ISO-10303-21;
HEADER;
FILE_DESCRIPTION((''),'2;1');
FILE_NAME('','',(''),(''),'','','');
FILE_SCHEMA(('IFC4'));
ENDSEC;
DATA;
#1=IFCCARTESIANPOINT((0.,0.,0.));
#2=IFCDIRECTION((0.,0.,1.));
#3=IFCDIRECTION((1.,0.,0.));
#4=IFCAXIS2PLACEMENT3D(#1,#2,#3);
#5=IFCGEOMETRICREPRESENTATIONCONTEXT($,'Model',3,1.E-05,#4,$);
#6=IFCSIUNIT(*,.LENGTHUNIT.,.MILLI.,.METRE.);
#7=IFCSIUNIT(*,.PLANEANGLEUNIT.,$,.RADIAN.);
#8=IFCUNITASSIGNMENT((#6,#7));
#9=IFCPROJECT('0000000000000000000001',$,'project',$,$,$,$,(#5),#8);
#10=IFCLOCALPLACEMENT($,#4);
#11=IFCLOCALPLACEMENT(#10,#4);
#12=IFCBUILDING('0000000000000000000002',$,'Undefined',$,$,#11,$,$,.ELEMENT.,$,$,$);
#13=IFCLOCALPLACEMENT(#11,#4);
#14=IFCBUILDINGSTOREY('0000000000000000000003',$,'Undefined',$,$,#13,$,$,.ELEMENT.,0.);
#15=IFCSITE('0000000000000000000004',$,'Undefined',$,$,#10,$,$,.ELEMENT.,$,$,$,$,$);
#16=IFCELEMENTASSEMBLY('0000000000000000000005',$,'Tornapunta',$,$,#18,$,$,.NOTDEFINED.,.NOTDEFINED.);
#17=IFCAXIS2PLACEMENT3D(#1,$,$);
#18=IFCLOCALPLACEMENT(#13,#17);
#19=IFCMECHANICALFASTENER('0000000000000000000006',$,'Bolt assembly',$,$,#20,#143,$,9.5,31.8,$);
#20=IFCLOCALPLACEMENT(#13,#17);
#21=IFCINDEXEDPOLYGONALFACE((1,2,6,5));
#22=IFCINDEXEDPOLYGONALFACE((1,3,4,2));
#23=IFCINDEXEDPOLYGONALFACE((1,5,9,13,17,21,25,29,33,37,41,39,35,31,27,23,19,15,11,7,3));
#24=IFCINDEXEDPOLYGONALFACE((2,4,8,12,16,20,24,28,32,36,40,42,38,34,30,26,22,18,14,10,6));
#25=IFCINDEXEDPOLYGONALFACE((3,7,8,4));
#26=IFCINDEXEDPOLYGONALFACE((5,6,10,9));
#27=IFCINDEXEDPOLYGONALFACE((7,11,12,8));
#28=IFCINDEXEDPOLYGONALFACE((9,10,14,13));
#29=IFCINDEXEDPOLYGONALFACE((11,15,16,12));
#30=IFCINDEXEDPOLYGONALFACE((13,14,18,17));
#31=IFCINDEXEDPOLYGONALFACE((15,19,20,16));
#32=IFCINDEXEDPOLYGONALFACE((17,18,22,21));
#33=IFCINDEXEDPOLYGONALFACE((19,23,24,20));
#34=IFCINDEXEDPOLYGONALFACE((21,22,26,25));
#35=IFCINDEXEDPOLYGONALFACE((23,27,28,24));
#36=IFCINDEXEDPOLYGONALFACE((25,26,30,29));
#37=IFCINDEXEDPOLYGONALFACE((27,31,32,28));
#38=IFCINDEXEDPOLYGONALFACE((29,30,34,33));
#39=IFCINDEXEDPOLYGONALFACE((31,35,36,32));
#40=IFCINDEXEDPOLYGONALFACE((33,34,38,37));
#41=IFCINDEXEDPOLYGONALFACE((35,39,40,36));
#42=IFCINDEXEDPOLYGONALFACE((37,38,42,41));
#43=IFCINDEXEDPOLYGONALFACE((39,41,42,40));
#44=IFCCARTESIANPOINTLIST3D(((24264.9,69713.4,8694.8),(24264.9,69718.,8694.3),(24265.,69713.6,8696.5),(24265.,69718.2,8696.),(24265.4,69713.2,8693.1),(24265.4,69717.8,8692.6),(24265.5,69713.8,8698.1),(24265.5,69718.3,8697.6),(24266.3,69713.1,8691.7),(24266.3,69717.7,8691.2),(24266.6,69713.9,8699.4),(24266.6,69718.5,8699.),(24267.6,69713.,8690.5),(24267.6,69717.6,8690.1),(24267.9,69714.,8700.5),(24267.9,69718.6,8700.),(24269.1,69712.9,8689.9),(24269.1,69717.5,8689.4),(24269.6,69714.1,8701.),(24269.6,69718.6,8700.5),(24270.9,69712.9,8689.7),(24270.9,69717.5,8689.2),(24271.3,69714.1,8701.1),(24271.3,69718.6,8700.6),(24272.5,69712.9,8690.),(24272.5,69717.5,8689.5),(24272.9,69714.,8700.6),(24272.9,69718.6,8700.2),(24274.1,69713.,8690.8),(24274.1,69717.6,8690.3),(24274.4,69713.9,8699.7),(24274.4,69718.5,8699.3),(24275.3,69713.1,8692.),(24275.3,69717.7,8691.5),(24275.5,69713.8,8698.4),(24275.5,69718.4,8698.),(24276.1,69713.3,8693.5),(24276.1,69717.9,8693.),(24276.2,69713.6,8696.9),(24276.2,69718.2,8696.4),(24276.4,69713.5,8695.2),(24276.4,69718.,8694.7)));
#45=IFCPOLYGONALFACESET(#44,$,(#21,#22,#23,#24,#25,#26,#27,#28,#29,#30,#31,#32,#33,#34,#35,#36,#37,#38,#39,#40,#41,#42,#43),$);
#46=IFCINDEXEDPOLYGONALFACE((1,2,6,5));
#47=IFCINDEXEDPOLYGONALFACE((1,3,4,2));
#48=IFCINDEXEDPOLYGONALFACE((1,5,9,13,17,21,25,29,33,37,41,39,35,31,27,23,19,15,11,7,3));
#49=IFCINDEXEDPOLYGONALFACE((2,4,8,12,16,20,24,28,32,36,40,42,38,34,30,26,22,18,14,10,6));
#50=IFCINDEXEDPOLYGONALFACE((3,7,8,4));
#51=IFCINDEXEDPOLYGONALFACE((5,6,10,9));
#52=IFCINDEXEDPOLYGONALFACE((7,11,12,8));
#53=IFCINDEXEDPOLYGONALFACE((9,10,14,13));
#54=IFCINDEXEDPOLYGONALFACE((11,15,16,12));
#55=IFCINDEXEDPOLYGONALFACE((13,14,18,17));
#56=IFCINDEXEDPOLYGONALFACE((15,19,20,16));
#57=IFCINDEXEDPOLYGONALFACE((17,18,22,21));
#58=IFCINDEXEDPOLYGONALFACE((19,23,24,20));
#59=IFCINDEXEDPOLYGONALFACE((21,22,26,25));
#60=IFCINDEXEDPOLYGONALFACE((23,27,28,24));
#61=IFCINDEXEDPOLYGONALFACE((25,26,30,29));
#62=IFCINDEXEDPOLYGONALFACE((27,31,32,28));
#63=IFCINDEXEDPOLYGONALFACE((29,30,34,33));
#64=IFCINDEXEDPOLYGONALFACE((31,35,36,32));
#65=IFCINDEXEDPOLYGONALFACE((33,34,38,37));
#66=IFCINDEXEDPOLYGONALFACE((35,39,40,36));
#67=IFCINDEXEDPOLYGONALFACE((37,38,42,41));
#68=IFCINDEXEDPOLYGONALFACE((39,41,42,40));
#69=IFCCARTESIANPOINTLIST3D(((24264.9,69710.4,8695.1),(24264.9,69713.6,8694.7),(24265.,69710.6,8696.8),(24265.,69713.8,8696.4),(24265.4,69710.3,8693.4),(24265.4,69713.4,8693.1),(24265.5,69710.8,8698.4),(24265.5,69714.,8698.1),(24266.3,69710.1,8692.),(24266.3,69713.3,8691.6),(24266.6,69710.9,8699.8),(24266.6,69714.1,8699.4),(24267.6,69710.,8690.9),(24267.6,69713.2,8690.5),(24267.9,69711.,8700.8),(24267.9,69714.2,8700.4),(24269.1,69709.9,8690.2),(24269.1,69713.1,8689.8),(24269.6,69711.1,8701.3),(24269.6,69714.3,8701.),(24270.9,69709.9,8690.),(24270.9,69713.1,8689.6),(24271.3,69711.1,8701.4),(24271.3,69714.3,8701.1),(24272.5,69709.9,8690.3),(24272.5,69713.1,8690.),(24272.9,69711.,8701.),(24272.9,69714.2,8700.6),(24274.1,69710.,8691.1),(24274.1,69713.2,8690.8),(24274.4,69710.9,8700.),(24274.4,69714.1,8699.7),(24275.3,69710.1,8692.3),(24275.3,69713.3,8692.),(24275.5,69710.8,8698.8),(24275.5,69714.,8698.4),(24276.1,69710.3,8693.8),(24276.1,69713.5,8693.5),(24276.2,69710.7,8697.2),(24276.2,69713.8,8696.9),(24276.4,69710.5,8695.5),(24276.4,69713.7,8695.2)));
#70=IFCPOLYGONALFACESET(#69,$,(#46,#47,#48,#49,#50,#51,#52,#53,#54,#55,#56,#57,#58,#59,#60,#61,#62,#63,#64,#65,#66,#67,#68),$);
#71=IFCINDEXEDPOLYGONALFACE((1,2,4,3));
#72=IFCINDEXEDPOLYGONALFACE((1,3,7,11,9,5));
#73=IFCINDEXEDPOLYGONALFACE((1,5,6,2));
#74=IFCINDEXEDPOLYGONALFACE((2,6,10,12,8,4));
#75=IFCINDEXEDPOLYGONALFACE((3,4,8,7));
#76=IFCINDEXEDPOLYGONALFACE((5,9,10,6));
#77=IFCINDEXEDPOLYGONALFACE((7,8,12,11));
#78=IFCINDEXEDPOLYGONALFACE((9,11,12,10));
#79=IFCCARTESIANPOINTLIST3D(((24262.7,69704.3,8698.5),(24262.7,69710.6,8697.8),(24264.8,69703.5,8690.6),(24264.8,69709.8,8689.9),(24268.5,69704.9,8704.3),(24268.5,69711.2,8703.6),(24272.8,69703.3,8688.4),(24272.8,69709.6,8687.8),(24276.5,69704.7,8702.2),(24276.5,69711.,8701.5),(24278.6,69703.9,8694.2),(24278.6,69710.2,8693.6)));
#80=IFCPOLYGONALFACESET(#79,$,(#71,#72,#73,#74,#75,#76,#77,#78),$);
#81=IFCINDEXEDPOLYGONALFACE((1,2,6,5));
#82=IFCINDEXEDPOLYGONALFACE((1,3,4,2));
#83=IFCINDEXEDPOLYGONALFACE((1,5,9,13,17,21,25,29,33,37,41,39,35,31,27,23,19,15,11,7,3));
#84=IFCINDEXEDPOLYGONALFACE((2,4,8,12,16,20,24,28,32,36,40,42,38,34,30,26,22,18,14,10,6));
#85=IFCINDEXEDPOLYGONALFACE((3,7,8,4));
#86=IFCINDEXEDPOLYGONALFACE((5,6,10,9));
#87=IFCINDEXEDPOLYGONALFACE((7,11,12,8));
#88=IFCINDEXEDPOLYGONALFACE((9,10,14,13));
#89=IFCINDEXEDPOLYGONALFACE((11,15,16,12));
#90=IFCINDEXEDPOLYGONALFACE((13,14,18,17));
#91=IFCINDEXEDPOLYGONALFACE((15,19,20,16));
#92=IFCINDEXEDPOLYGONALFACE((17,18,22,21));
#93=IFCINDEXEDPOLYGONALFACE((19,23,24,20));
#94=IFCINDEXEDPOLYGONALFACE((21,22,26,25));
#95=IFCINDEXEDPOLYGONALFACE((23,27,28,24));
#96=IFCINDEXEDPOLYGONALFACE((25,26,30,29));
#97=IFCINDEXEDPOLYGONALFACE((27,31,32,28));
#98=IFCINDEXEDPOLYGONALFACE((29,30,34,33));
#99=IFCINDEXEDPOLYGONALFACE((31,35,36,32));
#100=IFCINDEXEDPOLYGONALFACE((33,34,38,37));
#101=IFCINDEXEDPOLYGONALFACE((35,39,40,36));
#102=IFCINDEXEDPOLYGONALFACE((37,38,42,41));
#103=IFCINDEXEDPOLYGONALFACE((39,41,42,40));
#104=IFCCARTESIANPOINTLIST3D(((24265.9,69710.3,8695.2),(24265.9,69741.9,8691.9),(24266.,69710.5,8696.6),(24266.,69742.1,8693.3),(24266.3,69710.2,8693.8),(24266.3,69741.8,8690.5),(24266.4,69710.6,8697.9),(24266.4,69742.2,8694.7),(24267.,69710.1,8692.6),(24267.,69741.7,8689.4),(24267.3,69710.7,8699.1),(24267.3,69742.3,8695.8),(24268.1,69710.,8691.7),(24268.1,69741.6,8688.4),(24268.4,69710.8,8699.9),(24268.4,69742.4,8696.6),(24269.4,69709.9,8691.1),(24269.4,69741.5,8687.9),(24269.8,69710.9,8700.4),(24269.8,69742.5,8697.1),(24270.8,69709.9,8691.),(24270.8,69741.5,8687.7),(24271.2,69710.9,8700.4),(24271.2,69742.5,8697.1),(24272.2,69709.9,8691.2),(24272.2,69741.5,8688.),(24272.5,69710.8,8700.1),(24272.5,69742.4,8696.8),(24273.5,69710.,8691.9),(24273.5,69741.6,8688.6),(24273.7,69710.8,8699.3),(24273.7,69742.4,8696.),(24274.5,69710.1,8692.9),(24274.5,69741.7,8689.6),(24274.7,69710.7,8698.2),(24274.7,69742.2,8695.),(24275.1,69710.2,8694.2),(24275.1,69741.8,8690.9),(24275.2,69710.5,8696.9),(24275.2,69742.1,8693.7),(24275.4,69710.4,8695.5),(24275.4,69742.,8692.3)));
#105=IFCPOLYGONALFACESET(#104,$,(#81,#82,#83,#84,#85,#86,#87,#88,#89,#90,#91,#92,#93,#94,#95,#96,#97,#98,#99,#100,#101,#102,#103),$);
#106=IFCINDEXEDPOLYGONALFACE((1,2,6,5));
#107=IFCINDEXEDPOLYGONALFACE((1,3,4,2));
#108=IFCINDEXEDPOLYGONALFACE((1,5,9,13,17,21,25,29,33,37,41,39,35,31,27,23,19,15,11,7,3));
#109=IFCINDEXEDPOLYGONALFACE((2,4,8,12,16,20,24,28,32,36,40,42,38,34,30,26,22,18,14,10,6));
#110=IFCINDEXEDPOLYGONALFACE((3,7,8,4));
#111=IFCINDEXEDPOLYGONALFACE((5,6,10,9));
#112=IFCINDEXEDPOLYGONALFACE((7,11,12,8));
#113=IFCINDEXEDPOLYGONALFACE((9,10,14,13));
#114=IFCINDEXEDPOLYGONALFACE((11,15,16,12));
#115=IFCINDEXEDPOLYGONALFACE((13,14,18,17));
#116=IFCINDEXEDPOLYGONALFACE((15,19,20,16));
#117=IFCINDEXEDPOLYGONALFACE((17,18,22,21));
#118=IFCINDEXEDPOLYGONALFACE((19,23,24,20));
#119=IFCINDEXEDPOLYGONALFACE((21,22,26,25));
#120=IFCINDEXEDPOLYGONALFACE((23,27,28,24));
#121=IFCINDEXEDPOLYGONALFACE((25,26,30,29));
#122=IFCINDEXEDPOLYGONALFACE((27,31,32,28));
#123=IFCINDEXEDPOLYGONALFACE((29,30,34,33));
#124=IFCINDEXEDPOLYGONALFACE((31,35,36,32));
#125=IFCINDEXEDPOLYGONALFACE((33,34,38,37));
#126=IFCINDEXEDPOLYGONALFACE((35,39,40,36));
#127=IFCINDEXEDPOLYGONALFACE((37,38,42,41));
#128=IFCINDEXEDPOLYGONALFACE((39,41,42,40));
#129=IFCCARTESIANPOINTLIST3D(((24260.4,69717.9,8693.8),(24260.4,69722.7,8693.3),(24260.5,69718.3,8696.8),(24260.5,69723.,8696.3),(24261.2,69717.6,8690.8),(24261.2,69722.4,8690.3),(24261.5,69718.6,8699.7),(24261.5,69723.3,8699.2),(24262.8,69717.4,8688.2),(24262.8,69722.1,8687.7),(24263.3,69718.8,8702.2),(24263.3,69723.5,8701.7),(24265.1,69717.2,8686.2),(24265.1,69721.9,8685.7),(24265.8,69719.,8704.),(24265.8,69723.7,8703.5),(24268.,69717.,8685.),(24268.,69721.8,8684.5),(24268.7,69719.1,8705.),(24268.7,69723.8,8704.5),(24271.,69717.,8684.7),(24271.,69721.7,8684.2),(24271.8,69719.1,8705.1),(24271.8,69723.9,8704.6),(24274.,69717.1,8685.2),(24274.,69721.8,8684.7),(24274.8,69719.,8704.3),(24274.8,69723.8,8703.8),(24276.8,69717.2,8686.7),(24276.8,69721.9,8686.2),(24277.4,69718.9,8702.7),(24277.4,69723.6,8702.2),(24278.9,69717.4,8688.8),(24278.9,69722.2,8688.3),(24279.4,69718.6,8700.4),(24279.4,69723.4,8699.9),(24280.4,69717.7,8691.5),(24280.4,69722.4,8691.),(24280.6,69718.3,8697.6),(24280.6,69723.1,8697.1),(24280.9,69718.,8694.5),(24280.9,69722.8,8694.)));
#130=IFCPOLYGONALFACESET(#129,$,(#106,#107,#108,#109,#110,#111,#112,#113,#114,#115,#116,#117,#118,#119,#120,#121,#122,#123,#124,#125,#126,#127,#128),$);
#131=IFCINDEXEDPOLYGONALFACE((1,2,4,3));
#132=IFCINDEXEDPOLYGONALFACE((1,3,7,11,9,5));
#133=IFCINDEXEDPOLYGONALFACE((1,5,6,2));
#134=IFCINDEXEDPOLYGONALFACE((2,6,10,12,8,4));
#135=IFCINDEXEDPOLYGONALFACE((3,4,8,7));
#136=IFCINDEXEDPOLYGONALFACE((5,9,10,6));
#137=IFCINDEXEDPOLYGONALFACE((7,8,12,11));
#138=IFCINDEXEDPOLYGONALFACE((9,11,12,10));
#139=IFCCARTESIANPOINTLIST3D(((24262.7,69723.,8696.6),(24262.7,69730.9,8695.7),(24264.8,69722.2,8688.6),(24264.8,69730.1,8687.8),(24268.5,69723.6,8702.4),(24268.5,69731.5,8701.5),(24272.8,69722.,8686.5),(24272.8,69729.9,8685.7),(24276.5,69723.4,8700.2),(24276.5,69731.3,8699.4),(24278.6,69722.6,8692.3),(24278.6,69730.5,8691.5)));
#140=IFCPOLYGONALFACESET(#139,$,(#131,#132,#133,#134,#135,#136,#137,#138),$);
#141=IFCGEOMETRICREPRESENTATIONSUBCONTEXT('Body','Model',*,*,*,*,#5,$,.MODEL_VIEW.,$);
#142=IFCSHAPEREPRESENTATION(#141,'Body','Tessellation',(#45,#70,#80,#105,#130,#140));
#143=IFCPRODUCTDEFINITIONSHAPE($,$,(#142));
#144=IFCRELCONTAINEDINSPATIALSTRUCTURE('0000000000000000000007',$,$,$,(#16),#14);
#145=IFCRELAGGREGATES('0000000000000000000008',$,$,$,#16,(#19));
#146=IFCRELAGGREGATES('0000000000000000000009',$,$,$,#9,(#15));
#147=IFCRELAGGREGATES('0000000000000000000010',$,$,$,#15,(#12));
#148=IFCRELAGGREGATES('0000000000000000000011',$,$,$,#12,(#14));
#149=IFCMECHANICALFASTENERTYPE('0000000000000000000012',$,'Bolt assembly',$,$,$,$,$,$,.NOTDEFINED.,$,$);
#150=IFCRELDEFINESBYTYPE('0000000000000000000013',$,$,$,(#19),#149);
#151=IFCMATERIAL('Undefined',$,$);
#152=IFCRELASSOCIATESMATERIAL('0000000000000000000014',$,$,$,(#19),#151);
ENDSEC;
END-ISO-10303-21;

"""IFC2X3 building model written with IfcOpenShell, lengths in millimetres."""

from ifc_helpers import new_model, si_unit, frame, origin_with_axes, origin_2d_with_axis, place, context, subcontext, project, spatial, polyline, circle, outline, extrude, source, transform, mapped, material, type_object, element, aggregate, save


model = new_model("IFC2X3")

# Units and contexts
model_context = context("Model", 3, precision=1e-05, world=origin_with_axes())
body_context = subcontext(model_context, "Body", "Model", "MODEL_VIEW")
ifc_project = project(units=[si_unit("LENGTHUNIT", "METRE", prefix="MILLI"), si_unit("PLANEANGLEUNIT", "RADIAN")], contexts=[model_context])

# Site, building, storey
site_placement = place(None, origin_with_axes())
site = spatial("IfcSite", under=ifc_project, at=site_placement, Name="Undefined", CompositionType="ELEMENT")
building_placement = place(site_placement, origin_with_axes())
building = spatial("IfcBuilding", under=site, at=building_placement, Name="Undefined", CompositionType="ELEMENT")
storey_placement = place(building_placement, origin_with_axes())
storey = spatial("IfcBuildingStorey", under=building, at=storey_placement, Name="Undefined", CompositionType="ELEMENT", Elevation=0.0)

# Element assembly
assembly_1_placement = place(storey_placement, origin_with_axes())
assembly_1 = element("IfcElementAssembly", 1, at=assembly_1_placement, inside=storey, Name="Tornapunta", AssemblyPlace="NOTDEFINED", PredefinedType="NOTDEFINED")
ifc_material_1 = material(Name="Undefined")
mechanical_fastener_type = type_object("IfcMechanicalFastenerType", Name="Bolt assembly")

# Mechanical fastener
shared_shape_1 = source(origin_with_axes(), body_context, "Body", "SweptSolid", [
    extrude(circle(Radius=5.8, at=origin_2d_with_axis()), frame((0.0, -0.1, 0.0), z_axis=(0.0, 1.0, 0.0), x_axis=(1.0, 0.0, 0.0)), (0.0, 0.0, 1.0), 4.6),
    extrude(circle(Radius=5.8, at=origin_2d_with_axis()), frame((0.0, -3.1, 0.0), z_axis=(0.0, 1.0, 0.0), x_axis=(1.0, 0.0, 0.0)), (0.0, 0.0, 1.0), 3.2),
    extrude(outline(polyline([(7.1, -4.1), (7.1, 4.1), (0.0, 8.2), (-7.1, 4.1), (-7.1, -4.1), (0.0, -8.2), (7.1, -4.1)])), frame((0.0, -9.5, 0.0), z_axis=(0.0, 1.0, 0.0), x_axis=(1.0, 0.0, 0.0)), (0.0, 0.0, 1.0), 6.3),
    extrude(circle(Radius=4.8, at=origin_2d_with_axis()), frame((0.0, -3.2, 0.0), z_axis=(0.0, 1.0, 0.0), x_axis=(1.0, 0.0, 0.0)), (0.0, 0.0, 1.0), 31.8),
    extrude(circle(Radius=10.3, at=origin_2d_with_axis()), frame((0.0, 4.5, 0.0), z_axis=(0.0, 1.0, 0.0), x_axis=(1.0, 0.0, 0.0)), (0.0, 0.0, 1.0), 4.8),
    extrude(outline(polyline([(7.1, -4.1), (7.1, 4.1), (0.0, 8.2), (-7.1, 4.1), (-7.1, -4.1), (0.0, -8.2), (7.1, -4.1)])), frame((0.0, 9.3, 0.0), z_axis=(0.0, 1.0, 0.0), x_axis=(1.0, 0.0, 0.0)), (0.0, 0.0, 1.0), 7.9),
])
mechanical_fastener_1_placement = place(assembly_1_placement, frame((24270.6, 69713.6, 8695.4), z_axis=(-0.707107, -0.072947, -0.703334), x_axis=(-0.707107, 0.072947, 0.703334)))
mechanical_fastener_1 = element("IfcMechanicalFastener", 2, at=mechanical_fastener_1_placement, type_object=mechanical_fastener_type, material=ifc_material_1, Name="Bolt assembly", NominalDiameter=9.5, NominalLength=31.8, context=body_context, shape_type="MappedRepresentation", body=[
    mapped(shared_shape_1, transform((0.0, 0.0, 0.0))),
])
aggregate(assembly_1, [mechanical_fastener_1])

save(model, "model.ifc")
